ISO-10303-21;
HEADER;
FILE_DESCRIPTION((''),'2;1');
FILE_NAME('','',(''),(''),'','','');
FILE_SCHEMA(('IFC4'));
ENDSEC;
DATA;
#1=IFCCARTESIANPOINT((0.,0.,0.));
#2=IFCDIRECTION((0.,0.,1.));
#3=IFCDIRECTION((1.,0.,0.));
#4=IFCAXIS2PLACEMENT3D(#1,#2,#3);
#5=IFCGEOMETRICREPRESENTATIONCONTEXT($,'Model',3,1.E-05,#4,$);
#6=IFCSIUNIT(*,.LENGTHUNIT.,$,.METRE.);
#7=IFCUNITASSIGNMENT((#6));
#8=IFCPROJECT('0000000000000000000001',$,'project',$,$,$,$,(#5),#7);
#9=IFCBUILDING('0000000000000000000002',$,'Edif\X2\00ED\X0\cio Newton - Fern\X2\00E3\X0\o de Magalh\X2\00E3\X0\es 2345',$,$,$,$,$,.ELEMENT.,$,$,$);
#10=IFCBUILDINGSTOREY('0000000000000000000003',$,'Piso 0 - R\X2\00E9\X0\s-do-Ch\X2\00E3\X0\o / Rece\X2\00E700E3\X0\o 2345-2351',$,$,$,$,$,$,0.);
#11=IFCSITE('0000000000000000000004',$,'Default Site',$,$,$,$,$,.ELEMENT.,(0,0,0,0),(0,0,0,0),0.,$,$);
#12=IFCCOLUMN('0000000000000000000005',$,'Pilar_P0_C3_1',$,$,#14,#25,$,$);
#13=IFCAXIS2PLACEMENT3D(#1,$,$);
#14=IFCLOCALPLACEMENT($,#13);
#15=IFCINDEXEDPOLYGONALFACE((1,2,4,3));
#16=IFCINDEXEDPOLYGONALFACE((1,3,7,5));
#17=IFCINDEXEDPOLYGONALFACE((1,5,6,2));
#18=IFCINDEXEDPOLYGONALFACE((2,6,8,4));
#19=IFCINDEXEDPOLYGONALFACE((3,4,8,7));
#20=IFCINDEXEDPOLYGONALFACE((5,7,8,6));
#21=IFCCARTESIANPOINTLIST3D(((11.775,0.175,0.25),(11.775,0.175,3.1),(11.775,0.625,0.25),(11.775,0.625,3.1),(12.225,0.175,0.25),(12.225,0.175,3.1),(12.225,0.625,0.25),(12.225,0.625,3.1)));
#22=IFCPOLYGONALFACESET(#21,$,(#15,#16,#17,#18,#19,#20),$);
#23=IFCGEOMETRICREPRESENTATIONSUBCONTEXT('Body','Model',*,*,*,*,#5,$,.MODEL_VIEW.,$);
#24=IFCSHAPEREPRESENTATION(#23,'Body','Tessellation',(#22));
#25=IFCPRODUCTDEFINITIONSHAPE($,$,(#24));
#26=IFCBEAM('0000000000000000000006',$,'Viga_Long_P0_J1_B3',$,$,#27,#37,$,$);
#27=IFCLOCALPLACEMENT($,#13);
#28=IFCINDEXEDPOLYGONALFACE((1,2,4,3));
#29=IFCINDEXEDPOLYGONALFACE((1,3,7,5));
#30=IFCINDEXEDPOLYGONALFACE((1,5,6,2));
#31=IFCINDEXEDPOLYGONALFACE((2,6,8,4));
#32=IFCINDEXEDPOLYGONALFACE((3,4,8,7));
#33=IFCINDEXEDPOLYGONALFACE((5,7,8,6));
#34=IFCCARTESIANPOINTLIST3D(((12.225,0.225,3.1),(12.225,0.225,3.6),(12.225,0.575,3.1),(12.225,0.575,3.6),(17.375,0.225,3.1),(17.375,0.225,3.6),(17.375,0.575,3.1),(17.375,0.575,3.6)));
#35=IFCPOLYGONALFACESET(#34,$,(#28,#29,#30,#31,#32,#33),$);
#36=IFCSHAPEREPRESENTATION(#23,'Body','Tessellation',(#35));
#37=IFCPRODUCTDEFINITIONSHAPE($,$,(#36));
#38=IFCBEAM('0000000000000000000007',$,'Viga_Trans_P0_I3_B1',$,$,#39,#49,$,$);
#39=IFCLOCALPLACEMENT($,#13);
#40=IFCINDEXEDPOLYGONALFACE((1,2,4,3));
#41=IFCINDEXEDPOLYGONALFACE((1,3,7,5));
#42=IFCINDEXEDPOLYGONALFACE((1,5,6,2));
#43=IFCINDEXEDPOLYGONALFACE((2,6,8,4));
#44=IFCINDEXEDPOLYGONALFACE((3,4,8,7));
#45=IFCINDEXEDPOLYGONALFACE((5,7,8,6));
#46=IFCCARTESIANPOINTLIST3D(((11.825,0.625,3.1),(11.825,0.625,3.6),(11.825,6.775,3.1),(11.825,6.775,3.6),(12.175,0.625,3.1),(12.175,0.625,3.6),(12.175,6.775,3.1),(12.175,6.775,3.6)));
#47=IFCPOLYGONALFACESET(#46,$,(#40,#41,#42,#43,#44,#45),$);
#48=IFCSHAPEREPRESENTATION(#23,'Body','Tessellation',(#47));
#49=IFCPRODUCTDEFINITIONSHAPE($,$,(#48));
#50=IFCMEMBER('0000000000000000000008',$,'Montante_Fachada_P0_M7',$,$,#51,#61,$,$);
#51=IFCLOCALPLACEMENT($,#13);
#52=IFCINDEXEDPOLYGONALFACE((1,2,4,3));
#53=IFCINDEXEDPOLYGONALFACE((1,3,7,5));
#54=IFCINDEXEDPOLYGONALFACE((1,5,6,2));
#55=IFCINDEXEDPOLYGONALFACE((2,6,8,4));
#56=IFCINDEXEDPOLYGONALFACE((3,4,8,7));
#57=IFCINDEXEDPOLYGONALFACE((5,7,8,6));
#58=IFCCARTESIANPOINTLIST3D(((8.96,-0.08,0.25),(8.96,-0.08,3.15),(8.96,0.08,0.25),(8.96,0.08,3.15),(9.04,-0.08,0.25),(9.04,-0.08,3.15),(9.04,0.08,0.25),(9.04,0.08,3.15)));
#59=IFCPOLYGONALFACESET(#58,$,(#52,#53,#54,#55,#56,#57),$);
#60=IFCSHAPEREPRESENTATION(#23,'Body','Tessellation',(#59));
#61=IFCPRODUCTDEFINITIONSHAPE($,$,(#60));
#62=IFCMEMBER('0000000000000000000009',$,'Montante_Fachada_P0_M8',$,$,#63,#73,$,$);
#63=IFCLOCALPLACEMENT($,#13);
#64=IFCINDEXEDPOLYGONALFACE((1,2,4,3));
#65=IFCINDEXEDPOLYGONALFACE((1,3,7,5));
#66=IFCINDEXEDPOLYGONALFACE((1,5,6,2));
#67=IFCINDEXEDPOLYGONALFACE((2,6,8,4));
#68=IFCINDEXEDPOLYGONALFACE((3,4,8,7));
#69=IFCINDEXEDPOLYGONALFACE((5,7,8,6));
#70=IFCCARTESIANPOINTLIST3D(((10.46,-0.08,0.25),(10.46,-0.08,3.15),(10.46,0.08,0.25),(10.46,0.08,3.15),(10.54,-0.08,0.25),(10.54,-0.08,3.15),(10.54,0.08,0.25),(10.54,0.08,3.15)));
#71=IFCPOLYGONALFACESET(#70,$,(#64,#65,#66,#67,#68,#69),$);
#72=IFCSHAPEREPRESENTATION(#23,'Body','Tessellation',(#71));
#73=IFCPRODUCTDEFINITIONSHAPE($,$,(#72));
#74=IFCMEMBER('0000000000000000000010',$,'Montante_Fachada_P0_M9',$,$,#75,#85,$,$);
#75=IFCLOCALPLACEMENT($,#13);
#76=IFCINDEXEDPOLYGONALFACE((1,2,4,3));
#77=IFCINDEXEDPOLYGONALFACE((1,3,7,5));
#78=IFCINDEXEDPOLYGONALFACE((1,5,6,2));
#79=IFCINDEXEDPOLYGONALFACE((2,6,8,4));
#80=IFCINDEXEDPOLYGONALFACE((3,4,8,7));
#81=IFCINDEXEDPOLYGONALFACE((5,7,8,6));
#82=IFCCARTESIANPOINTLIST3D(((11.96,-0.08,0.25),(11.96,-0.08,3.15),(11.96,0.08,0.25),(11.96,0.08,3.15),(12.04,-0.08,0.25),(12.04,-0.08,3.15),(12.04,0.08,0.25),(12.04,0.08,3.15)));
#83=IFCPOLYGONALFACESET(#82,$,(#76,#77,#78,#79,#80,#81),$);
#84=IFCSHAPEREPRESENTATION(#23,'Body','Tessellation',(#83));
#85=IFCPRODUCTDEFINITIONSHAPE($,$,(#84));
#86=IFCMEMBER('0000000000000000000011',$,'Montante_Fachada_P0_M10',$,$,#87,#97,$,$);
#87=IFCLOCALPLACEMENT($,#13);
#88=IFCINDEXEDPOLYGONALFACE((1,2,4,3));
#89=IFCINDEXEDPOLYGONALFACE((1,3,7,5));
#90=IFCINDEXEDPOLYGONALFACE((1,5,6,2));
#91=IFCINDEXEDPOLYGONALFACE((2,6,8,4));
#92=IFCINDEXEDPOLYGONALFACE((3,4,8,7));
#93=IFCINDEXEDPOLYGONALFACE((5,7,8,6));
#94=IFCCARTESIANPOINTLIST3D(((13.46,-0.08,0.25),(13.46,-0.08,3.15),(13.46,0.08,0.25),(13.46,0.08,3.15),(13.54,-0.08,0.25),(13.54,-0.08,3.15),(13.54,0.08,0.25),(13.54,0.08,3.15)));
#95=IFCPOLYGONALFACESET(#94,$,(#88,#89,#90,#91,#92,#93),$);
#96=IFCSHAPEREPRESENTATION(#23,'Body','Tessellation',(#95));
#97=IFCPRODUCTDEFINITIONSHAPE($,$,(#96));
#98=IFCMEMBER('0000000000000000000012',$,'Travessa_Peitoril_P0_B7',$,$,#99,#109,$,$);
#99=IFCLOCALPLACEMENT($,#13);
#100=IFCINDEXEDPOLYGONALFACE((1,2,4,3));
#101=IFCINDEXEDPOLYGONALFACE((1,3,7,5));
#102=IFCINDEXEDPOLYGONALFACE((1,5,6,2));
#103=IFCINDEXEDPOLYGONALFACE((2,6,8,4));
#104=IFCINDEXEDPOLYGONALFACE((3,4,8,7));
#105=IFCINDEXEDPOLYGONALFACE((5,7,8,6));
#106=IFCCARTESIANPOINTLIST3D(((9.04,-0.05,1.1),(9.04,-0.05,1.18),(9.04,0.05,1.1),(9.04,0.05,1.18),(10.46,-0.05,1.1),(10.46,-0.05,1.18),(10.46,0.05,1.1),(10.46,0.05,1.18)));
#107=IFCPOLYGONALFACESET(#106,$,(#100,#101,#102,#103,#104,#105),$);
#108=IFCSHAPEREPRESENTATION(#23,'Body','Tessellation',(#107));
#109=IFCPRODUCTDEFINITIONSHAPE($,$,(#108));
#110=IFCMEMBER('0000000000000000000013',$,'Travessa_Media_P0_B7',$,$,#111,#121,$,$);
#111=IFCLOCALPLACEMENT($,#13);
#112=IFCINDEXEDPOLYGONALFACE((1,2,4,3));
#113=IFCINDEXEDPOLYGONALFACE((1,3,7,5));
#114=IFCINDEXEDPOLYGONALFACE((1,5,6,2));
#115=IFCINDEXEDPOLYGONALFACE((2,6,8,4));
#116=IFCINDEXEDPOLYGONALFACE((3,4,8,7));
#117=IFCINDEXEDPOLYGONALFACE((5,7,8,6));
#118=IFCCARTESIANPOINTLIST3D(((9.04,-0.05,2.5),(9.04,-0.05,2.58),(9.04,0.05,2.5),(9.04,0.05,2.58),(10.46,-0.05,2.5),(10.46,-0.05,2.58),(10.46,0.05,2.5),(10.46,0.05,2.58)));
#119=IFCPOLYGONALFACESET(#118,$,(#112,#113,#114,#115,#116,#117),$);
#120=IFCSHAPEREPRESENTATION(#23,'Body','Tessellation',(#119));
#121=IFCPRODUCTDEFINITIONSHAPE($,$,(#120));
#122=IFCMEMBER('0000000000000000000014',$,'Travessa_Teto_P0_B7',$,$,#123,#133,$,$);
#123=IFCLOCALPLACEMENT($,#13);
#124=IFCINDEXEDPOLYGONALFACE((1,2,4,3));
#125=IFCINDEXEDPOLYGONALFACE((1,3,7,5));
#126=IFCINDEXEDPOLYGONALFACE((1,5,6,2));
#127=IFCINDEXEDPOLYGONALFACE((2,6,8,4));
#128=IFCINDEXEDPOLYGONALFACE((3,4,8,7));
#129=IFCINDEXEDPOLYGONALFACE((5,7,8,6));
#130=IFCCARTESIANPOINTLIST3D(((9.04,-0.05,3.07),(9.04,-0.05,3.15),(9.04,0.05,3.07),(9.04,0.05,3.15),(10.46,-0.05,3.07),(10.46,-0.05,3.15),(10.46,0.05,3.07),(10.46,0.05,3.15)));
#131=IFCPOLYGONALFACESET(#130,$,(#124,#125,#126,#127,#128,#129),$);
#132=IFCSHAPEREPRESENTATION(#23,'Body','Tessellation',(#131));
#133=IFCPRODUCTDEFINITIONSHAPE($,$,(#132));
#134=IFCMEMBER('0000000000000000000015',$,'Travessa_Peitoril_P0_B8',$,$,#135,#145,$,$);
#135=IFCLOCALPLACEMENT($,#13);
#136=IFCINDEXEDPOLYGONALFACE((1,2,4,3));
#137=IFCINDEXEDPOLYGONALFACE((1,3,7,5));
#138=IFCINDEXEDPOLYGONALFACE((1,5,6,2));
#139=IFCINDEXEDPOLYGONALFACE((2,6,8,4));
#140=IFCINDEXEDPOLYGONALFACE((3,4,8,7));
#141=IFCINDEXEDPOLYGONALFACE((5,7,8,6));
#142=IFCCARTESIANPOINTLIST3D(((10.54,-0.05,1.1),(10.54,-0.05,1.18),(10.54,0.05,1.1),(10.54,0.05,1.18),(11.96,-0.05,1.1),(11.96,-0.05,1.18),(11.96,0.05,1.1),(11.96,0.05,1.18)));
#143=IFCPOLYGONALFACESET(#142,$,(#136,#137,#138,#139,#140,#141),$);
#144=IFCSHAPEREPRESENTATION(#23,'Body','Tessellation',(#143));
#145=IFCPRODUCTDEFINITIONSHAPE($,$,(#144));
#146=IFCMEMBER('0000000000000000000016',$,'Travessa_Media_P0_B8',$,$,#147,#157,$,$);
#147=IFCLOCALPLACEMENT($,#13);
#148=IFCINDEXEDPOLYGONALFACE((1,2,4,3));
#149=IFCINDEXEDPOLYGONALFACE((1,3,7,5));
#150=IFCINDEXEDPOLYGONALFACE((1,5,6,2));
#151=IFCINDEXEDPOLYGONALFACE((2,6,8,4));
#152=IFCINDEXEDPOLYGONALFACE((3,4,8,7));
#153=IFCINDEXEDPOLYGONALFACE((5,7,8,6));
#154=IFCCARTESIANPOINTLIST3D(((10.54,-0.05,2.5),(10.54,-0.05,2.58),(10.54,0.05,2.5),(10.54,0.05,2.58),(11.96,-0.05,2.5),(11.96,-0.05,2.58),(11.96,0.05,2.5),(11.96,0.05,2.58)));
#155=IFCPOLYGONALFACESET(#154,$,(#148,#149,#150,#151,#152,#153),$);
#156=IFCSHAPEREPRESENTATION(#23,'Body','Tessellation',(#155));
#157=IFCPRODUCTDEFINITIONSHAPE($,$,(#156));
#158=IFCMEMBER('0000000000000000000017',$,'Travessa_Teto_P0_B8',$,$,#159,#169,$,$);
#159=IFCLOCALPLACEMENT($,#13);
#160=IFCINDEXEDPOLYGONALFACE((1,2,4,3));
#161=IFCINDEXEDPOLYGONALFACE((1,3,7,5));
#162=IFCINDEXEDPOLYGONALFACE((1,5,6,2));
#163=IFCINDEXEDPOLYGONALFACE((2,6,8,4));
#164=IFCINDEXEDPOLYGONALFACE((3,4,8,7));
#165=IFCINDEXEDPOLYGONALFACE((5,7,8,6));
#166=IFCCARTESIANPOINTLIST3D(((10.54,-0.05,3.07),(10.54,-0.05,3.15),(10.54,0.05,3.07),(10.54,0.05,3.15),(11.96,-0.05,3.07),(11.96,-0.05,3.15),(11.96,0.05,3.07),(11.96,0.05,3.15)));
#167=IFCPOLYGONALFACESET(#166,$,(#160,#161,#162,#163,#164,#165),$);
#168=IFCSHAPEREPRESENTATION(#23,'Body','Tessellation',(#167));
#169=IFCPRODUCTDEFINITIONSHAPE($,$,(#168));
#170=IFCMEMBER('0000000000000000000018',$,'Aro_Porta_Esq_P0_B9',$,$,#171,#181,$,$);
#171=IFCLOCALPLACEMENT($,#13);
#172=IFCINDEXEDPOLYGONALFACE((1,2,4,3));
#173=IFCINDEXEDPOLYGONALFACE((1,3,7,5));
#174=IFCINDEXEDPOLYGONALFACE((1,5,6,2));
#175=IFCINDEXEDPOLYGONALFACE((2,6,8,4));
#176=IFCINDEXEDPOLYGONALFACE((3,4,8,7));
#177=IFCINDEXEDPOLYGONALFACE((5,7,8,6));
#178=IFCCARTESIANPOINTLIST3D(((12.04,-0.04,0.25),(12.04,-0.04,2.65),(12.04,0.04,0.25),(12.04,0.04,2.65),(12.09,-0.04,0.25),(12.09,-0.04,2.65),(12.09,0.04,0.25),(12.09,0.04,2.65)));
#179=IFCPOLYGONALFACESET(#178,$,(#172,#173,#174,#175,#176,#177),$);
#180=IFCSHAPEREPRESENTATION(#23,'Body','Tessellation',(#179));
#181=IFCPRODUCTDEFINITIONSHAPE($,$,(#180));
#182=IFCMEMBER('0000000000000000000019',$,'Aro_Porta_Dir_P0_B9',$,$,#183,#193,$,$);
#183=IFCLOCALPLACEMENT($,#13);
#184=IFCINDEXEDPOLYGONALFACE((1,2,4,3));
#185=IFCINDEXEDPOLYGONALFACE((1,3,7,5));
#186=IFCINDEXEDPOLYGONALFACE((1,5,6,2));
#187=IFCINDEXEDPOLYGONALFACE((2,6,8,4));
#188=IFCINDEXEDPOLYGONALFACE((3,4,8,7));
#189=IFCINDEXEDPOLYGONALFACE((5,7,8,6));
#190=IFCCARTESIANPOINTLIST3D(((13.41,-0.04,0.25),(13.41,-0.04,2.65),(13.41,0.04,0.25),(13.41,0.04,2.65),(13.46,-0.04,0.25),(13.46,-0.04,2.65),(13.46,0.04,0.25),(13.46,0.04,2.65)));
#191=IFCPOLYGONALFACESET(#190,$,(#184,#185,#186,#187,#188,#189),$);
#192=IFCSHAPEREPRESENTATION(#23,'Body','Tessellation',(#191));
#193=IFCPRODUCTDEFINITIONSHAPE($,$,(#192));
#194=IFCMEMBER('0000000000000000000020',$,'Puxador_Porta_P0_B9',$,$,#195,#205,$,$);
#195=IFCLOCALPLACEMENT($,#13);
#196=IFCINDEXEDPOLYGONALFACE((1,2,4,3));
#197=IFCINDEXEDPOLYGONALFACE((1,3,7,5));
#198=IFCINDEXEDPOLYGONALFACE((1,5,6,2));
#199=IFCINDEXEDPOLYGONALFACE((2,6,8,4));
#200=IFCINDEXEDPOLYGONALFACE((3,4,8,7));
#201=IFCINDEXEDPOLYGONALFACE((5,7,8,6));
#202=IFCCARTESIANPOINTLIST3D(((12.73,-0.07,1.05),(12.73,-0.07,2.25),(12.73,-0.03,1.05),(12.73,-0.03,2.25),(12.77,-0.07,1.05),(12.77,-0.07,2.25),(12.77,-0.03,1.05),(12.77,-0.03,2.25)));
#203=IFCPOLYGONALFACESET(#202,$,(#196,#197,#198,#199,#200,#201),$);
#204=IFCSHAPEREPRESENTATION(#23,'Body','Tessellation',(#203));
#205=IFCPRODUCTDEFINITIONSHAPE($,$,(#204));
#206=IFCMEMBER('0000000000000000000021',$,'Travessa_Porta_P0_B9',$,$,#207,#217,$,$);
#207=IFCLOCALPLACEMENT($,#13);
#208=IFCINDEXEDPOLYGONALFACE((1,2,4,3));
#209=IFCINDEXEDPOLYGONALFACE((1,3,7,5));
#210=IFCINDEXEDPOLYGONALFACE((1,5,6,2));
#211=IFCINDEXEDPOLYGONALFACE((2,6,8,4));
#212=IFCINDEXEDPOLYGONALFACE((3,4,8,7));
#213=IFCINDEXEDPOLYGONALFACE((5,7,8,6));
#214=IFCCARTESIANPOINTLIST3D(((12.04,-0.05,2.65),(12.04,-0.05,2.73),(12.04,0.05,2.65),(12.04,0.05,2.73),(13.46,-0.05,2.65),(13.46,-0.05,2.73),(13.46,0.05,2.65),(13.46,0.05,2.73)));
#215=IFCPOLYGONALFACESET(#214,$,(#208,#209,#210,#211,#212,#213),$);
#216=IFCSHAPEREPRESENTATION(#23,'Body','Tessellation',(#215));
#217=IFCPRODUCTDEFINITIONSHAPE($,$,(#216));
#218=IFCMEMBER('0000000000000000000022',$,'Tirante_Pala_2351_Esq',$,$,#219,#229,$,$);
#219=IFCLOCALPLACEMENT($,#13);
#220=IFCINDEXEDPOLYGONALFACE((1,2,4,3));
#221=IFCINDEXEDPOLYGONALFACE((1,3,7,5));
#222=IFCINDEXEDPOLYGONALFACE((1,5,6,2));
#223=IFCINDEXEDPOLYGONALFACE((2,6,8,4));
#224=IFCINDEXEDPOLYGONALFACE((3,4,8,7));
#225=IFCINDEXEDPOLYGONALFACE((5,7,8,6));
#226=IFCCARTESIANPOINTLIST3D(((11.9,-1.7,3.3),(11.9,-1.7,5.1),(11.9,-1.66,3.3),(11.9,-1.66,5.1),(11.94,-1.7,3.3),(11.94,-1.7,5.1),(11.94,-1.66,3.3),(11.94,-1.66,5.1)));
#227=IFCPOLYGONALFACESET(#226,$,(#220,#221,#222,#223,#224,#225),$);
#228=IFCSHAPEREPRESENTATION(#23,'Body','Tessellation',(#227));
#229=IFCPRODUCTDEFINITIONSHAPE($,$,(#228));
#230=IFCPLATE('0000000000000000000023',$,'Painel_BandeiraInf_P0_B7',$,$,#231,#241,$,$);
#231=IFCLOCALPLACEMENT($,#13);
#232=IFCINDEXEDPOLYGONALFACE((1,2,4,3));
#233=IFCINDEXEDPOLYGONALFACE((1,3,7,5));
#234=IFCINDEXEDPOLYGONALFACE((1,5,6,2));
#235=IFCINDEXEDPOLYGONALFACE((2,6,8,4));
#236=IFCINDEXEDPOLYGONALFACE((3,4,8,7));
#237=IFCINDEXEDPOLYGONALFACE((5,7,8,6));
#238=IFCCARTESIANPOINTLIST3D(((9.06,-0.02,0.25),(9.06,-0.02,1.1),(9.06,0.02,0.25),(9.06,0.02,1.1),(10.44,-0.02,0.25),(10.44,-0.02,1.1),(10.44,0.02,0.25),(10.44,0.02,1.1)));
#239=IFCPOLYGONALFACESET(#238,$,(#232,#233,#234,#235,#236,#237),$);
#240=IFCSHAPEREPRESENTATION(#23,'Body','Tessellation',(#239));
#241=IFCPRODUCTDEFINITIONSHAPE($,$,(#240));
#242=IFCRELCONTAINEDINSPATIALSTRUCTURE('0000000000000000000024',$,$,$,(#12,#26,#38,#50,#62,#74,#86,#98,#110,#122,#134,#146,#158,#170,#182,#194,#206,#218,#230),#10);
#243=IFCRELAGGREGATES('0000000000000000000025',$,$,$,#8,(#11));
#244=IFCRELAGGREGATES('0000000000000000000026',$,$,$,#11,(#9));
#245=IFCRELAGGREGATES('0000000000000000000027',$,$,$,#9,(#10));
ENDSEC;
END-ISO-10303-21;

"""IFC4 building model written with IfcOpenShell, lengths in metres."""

from ifc_helpers import new_model, si_unit, frame, frame_2d, origin_with_axes, place, context, subcontext, project, spatial, rectangle, extrude, element, save


model = new_model("IFC4")

# Units and contexts
model_context = context("Model", 3, precision=1e-05, world=origin_with_axes())
body_context = subcontext(model_context, "Body", "Model", "MODEL_VIEW")
ifc_project = project(units=[si_unit("LENGTHUNIT", "METRE")], contexts=[model_context])

# Site, building, storey
site = spatial("IfcSite", under=ifc_project, Name="Default Site", CompositionType="ELEMENT", RefLatitude=(0, 0, 0, 0), RefLongitude=(0, 0, 0, 0), RefElevation=0.0)
building = spatial("IfcBuilding", under=site, Name="Edifício Newton - Fernão de Magalhães 2345", CompositionType="ELEMENT")
storey = spatial("IfcBuildingStorey", under=building, Name="Piso 0 - Rés-do-Chão / Receção 2345-2351", Elevation=0.0)

# Column
column_placement = place(None, frame((11.775, 0.175, 0.25), z_axis=(0.0, 0.0, 1.0), x_axis=(1.0, 0.0, 0.0)))
element("IfcColumn", 1, at=column_placement, inside=storey, Name="Pilar_P0_C3_1", context=body_context, shape_type="SweptSolid", body=[
    extrude(rectangle(XDim=0.45, YDim=0.45, at=frame_2d((0.225, 0.225))), origin_with_axes(), (0.0, 0.0, 1.0), 2.85),
])

# Beams
beam_1_placement = place(None, frame((12.225, 0.225, 3.1), z_axis=(0.0, 0.0, 1.0), x_axis=(1.0, 0.0, 0.0)))
element("IfcBeam", 2, at=beam_1_placement, inside=storey, Name="Viga_Long_P0_J1_B3", context=body_context, shape_type="SweptSolid", body=[
    extrude(rectangle(XDim=5.15, YDim=0.35, at=frame_2d((2.575, 0.175))), origin_with_axes(), (0.0, 0.0, 1.0), 0.5),
])
beam_2_placement = place(None, frame((11.825, 0.625, 3.1), z_axis=(0.0, 0.0, 1.0), x_axis=(1.0, 0.0, 0.0)))
element("IfcBeam", 3, at=beam_2_placement, inside=storey, Name="Viga_Trans_P0_I3_B1", context=body_context, shape_type="SweptSolid", body=[
    extrude(rectangle(XDim=0.35, YDim=6.15, at=frame_2d((0.175, 3.075))), origin_with_axes(), (0.0, 0.0, 1.0), 0.5),
])

# Members
for number, where, z_axis, x_axis, name in (
    (4, (8.96, -0.08, 0.25), (0.0, 0.0, 1.0), (1.0, 0.0, 0.0), "Montante_Fachada_P0_M7"),
    (5, (10.46, -0.08, 0.25), (0.0, 0.0, 1.0), (1.0, 0.0, 0.0), "Montante_Fachada_P0_M8"),
    (6, (11.96, -0.08, 0.25), (0.0, 0.0, 1.0), (1.0, 0.0, 0.0), "Montante_Fachada_P0_M9"),
    (7, (13.46, -0.08, 0.25), (0.0, 0.0, 1.0), (1.0, 0.0, 0.0), "Montante_Fachada_P0_M10"),
):
    element("IfcMember", number, at=place(None, frame(where, z_axis=z_axis, x_axis=x_axis)), inside=storey, Name=name, context=body_context, shape_type="SweptSolid", body=[
        extrude(rectangle(XDim=0.08, YDim=0.16, at=frame_2d((0.04, 0.08))), origin_with_axes(), (0.0, 0.0, 1.0), 2.9),
    ])
for number, where, z_axis, x_axis, name in (
    (8, (9.04, -0.05, 1.1), (0.0, 0.0, 1.0), (1.0, 0.0, 0.0), "Travessa_Peitoril_P0_B7"),
    (9, (9.04, -0.05, 2.5), (0.0, 0.0, 1.0), (1.0, 0.0, 0.0), "Travessa_Media_P0_B7"),
    (10, (9.04, -0.05, 3.07), (0.0, 0.0, 1.0), (1.0, 0.0, 0.0), "Travessa_Teto_P0_B7"),
    (11, (10.54, -0.05, 1.1), (0.0, 0.0, 1.0), (1.0, 0.0, 0.0), "Travessa_Peitoril_P0_B8"),
    (12, (10.54, -0.05, 2.5), (0.0, 0.0, 1.0), (1.0, 0.0, 0.0), "Travessa_Media_P0_B8"),
    (13, (10.54, -0.05, 3.07), (0.0, 0.0, 1.0), (1.0, 0.0, 0.0), "Travessa_Teto_P0_B8"),
):
    element("IfcMember", number, at=place(None, frame(where, z_axis=z_axis, x_axis=x_axis)), inside=storey, Name=name, context=body_context, shape_type="SweptSolid", body=[
        extrude(rectangle(XDim=1.42, YDim=0.1, at=frame_2d((0.71, 0.05))), origin_with_axes(), (0.0, 0.0, 1.0), 0.08),
    ])
for number, where, z_axis, x_axis, name in (
    (14, (12.04, -0.04, 0.25), (0.0, 0.0, 1.0), (1.0, 0.0, 0.0), "Aro_Porta_Esq_P0_B9"),
    (15, (13.41, -0.04, 0.25), (0.0, 0.0, 1.0), (1.0, 0.0, 0.0), "Aro_Porta_Dir_P0_B9"),
):
    element("IfcMember", number, at=place(None, frame(where, z_axis=z_axis, x_axis=x_axis)), inside=storey, Name=name, context=body_context, shape_type="SweptSolid", body=[
        extrude(rectangle(XDim=0.05, YDim=0.08, at=frame_2d((0.025, 0.04))), origin_with_axes(), (0.0, 0.0, 1.0), 2.4),
    ])
member_1_placement = place(None, frame((12.73, -0.07, 1.05), z_axis=(0.0, 0.0, 1.0), x_axis=(1.0, 0.0, 0.0)))
element("IfcMember", 16, at=member_1_placement, inside=storey, Name="Puxador_Porta_P0_B9", context=body_context, shape_type="SweptSolid", body=[
    extrude(rectangle(XDim=0.04, YDim=0.04, at=frame_2d((0.02, 0.02))), origin_with_axes(), (0.0, 0.0, 1.0), 1.2),
])
member_2_placement = place(None, frame((12.04, -0.05, 2.65), z_axis=(0.0, 0.0, 1.0), x_axis=(1.0, 0.0, 0.0)))
element("IfcMember", 17, at=member_2_placement, inside=storey, Name="Travessa_Porta_P0_B9", context=body_context, shape_type="SweptSolid", body=[
    extrude(rectangle(XDim=1.42, YDim=0.1, at=frame_2d((0.71, 0.05))), origin_with_axes(), (0.0, 0.0, 1.0), 0.08),
])
member_3_placement = place(None, frame((11.9, -1.7, 3.3), z_axis=(0.0, 0.0, 1.0), x_axis=(1.0, 0.0, 0.0)))
element("IfcMember", 18, at=member_3_placement, inside=storey, Name="Tirante_Pala_2351_Esq", context=body_context, shape_type="SweptSolid", body=[
    extrude(rectangle(XDim=0.04, YDim=0.04, at=frame_2d((0.02, 0.02))), origin_with_axes(), (0.0, 0.0, 1.0), 1.8),
])

# Plate
plate_1_placement = place(None, frame((9.06, -0.02, 0.25), z_axis=(0.0, 0.0, 1.0), x_axis=(1.0, 0.0, 0.0)))
element("IfcPlate", 19, at=plate_1_placement, inside=storey, Name="Painel_BandeiraInf_P0_B7", context=body_context, shape_type="SweptSolid", body=[
    extrude(rectangle(XDim=1.38, YDim=0.04, at=frame_2d((0.69, 0.02))), origin_with_axes(), (0.0, 0.0, 1.0), 0.85),
])

save(model, "model.ifc")
